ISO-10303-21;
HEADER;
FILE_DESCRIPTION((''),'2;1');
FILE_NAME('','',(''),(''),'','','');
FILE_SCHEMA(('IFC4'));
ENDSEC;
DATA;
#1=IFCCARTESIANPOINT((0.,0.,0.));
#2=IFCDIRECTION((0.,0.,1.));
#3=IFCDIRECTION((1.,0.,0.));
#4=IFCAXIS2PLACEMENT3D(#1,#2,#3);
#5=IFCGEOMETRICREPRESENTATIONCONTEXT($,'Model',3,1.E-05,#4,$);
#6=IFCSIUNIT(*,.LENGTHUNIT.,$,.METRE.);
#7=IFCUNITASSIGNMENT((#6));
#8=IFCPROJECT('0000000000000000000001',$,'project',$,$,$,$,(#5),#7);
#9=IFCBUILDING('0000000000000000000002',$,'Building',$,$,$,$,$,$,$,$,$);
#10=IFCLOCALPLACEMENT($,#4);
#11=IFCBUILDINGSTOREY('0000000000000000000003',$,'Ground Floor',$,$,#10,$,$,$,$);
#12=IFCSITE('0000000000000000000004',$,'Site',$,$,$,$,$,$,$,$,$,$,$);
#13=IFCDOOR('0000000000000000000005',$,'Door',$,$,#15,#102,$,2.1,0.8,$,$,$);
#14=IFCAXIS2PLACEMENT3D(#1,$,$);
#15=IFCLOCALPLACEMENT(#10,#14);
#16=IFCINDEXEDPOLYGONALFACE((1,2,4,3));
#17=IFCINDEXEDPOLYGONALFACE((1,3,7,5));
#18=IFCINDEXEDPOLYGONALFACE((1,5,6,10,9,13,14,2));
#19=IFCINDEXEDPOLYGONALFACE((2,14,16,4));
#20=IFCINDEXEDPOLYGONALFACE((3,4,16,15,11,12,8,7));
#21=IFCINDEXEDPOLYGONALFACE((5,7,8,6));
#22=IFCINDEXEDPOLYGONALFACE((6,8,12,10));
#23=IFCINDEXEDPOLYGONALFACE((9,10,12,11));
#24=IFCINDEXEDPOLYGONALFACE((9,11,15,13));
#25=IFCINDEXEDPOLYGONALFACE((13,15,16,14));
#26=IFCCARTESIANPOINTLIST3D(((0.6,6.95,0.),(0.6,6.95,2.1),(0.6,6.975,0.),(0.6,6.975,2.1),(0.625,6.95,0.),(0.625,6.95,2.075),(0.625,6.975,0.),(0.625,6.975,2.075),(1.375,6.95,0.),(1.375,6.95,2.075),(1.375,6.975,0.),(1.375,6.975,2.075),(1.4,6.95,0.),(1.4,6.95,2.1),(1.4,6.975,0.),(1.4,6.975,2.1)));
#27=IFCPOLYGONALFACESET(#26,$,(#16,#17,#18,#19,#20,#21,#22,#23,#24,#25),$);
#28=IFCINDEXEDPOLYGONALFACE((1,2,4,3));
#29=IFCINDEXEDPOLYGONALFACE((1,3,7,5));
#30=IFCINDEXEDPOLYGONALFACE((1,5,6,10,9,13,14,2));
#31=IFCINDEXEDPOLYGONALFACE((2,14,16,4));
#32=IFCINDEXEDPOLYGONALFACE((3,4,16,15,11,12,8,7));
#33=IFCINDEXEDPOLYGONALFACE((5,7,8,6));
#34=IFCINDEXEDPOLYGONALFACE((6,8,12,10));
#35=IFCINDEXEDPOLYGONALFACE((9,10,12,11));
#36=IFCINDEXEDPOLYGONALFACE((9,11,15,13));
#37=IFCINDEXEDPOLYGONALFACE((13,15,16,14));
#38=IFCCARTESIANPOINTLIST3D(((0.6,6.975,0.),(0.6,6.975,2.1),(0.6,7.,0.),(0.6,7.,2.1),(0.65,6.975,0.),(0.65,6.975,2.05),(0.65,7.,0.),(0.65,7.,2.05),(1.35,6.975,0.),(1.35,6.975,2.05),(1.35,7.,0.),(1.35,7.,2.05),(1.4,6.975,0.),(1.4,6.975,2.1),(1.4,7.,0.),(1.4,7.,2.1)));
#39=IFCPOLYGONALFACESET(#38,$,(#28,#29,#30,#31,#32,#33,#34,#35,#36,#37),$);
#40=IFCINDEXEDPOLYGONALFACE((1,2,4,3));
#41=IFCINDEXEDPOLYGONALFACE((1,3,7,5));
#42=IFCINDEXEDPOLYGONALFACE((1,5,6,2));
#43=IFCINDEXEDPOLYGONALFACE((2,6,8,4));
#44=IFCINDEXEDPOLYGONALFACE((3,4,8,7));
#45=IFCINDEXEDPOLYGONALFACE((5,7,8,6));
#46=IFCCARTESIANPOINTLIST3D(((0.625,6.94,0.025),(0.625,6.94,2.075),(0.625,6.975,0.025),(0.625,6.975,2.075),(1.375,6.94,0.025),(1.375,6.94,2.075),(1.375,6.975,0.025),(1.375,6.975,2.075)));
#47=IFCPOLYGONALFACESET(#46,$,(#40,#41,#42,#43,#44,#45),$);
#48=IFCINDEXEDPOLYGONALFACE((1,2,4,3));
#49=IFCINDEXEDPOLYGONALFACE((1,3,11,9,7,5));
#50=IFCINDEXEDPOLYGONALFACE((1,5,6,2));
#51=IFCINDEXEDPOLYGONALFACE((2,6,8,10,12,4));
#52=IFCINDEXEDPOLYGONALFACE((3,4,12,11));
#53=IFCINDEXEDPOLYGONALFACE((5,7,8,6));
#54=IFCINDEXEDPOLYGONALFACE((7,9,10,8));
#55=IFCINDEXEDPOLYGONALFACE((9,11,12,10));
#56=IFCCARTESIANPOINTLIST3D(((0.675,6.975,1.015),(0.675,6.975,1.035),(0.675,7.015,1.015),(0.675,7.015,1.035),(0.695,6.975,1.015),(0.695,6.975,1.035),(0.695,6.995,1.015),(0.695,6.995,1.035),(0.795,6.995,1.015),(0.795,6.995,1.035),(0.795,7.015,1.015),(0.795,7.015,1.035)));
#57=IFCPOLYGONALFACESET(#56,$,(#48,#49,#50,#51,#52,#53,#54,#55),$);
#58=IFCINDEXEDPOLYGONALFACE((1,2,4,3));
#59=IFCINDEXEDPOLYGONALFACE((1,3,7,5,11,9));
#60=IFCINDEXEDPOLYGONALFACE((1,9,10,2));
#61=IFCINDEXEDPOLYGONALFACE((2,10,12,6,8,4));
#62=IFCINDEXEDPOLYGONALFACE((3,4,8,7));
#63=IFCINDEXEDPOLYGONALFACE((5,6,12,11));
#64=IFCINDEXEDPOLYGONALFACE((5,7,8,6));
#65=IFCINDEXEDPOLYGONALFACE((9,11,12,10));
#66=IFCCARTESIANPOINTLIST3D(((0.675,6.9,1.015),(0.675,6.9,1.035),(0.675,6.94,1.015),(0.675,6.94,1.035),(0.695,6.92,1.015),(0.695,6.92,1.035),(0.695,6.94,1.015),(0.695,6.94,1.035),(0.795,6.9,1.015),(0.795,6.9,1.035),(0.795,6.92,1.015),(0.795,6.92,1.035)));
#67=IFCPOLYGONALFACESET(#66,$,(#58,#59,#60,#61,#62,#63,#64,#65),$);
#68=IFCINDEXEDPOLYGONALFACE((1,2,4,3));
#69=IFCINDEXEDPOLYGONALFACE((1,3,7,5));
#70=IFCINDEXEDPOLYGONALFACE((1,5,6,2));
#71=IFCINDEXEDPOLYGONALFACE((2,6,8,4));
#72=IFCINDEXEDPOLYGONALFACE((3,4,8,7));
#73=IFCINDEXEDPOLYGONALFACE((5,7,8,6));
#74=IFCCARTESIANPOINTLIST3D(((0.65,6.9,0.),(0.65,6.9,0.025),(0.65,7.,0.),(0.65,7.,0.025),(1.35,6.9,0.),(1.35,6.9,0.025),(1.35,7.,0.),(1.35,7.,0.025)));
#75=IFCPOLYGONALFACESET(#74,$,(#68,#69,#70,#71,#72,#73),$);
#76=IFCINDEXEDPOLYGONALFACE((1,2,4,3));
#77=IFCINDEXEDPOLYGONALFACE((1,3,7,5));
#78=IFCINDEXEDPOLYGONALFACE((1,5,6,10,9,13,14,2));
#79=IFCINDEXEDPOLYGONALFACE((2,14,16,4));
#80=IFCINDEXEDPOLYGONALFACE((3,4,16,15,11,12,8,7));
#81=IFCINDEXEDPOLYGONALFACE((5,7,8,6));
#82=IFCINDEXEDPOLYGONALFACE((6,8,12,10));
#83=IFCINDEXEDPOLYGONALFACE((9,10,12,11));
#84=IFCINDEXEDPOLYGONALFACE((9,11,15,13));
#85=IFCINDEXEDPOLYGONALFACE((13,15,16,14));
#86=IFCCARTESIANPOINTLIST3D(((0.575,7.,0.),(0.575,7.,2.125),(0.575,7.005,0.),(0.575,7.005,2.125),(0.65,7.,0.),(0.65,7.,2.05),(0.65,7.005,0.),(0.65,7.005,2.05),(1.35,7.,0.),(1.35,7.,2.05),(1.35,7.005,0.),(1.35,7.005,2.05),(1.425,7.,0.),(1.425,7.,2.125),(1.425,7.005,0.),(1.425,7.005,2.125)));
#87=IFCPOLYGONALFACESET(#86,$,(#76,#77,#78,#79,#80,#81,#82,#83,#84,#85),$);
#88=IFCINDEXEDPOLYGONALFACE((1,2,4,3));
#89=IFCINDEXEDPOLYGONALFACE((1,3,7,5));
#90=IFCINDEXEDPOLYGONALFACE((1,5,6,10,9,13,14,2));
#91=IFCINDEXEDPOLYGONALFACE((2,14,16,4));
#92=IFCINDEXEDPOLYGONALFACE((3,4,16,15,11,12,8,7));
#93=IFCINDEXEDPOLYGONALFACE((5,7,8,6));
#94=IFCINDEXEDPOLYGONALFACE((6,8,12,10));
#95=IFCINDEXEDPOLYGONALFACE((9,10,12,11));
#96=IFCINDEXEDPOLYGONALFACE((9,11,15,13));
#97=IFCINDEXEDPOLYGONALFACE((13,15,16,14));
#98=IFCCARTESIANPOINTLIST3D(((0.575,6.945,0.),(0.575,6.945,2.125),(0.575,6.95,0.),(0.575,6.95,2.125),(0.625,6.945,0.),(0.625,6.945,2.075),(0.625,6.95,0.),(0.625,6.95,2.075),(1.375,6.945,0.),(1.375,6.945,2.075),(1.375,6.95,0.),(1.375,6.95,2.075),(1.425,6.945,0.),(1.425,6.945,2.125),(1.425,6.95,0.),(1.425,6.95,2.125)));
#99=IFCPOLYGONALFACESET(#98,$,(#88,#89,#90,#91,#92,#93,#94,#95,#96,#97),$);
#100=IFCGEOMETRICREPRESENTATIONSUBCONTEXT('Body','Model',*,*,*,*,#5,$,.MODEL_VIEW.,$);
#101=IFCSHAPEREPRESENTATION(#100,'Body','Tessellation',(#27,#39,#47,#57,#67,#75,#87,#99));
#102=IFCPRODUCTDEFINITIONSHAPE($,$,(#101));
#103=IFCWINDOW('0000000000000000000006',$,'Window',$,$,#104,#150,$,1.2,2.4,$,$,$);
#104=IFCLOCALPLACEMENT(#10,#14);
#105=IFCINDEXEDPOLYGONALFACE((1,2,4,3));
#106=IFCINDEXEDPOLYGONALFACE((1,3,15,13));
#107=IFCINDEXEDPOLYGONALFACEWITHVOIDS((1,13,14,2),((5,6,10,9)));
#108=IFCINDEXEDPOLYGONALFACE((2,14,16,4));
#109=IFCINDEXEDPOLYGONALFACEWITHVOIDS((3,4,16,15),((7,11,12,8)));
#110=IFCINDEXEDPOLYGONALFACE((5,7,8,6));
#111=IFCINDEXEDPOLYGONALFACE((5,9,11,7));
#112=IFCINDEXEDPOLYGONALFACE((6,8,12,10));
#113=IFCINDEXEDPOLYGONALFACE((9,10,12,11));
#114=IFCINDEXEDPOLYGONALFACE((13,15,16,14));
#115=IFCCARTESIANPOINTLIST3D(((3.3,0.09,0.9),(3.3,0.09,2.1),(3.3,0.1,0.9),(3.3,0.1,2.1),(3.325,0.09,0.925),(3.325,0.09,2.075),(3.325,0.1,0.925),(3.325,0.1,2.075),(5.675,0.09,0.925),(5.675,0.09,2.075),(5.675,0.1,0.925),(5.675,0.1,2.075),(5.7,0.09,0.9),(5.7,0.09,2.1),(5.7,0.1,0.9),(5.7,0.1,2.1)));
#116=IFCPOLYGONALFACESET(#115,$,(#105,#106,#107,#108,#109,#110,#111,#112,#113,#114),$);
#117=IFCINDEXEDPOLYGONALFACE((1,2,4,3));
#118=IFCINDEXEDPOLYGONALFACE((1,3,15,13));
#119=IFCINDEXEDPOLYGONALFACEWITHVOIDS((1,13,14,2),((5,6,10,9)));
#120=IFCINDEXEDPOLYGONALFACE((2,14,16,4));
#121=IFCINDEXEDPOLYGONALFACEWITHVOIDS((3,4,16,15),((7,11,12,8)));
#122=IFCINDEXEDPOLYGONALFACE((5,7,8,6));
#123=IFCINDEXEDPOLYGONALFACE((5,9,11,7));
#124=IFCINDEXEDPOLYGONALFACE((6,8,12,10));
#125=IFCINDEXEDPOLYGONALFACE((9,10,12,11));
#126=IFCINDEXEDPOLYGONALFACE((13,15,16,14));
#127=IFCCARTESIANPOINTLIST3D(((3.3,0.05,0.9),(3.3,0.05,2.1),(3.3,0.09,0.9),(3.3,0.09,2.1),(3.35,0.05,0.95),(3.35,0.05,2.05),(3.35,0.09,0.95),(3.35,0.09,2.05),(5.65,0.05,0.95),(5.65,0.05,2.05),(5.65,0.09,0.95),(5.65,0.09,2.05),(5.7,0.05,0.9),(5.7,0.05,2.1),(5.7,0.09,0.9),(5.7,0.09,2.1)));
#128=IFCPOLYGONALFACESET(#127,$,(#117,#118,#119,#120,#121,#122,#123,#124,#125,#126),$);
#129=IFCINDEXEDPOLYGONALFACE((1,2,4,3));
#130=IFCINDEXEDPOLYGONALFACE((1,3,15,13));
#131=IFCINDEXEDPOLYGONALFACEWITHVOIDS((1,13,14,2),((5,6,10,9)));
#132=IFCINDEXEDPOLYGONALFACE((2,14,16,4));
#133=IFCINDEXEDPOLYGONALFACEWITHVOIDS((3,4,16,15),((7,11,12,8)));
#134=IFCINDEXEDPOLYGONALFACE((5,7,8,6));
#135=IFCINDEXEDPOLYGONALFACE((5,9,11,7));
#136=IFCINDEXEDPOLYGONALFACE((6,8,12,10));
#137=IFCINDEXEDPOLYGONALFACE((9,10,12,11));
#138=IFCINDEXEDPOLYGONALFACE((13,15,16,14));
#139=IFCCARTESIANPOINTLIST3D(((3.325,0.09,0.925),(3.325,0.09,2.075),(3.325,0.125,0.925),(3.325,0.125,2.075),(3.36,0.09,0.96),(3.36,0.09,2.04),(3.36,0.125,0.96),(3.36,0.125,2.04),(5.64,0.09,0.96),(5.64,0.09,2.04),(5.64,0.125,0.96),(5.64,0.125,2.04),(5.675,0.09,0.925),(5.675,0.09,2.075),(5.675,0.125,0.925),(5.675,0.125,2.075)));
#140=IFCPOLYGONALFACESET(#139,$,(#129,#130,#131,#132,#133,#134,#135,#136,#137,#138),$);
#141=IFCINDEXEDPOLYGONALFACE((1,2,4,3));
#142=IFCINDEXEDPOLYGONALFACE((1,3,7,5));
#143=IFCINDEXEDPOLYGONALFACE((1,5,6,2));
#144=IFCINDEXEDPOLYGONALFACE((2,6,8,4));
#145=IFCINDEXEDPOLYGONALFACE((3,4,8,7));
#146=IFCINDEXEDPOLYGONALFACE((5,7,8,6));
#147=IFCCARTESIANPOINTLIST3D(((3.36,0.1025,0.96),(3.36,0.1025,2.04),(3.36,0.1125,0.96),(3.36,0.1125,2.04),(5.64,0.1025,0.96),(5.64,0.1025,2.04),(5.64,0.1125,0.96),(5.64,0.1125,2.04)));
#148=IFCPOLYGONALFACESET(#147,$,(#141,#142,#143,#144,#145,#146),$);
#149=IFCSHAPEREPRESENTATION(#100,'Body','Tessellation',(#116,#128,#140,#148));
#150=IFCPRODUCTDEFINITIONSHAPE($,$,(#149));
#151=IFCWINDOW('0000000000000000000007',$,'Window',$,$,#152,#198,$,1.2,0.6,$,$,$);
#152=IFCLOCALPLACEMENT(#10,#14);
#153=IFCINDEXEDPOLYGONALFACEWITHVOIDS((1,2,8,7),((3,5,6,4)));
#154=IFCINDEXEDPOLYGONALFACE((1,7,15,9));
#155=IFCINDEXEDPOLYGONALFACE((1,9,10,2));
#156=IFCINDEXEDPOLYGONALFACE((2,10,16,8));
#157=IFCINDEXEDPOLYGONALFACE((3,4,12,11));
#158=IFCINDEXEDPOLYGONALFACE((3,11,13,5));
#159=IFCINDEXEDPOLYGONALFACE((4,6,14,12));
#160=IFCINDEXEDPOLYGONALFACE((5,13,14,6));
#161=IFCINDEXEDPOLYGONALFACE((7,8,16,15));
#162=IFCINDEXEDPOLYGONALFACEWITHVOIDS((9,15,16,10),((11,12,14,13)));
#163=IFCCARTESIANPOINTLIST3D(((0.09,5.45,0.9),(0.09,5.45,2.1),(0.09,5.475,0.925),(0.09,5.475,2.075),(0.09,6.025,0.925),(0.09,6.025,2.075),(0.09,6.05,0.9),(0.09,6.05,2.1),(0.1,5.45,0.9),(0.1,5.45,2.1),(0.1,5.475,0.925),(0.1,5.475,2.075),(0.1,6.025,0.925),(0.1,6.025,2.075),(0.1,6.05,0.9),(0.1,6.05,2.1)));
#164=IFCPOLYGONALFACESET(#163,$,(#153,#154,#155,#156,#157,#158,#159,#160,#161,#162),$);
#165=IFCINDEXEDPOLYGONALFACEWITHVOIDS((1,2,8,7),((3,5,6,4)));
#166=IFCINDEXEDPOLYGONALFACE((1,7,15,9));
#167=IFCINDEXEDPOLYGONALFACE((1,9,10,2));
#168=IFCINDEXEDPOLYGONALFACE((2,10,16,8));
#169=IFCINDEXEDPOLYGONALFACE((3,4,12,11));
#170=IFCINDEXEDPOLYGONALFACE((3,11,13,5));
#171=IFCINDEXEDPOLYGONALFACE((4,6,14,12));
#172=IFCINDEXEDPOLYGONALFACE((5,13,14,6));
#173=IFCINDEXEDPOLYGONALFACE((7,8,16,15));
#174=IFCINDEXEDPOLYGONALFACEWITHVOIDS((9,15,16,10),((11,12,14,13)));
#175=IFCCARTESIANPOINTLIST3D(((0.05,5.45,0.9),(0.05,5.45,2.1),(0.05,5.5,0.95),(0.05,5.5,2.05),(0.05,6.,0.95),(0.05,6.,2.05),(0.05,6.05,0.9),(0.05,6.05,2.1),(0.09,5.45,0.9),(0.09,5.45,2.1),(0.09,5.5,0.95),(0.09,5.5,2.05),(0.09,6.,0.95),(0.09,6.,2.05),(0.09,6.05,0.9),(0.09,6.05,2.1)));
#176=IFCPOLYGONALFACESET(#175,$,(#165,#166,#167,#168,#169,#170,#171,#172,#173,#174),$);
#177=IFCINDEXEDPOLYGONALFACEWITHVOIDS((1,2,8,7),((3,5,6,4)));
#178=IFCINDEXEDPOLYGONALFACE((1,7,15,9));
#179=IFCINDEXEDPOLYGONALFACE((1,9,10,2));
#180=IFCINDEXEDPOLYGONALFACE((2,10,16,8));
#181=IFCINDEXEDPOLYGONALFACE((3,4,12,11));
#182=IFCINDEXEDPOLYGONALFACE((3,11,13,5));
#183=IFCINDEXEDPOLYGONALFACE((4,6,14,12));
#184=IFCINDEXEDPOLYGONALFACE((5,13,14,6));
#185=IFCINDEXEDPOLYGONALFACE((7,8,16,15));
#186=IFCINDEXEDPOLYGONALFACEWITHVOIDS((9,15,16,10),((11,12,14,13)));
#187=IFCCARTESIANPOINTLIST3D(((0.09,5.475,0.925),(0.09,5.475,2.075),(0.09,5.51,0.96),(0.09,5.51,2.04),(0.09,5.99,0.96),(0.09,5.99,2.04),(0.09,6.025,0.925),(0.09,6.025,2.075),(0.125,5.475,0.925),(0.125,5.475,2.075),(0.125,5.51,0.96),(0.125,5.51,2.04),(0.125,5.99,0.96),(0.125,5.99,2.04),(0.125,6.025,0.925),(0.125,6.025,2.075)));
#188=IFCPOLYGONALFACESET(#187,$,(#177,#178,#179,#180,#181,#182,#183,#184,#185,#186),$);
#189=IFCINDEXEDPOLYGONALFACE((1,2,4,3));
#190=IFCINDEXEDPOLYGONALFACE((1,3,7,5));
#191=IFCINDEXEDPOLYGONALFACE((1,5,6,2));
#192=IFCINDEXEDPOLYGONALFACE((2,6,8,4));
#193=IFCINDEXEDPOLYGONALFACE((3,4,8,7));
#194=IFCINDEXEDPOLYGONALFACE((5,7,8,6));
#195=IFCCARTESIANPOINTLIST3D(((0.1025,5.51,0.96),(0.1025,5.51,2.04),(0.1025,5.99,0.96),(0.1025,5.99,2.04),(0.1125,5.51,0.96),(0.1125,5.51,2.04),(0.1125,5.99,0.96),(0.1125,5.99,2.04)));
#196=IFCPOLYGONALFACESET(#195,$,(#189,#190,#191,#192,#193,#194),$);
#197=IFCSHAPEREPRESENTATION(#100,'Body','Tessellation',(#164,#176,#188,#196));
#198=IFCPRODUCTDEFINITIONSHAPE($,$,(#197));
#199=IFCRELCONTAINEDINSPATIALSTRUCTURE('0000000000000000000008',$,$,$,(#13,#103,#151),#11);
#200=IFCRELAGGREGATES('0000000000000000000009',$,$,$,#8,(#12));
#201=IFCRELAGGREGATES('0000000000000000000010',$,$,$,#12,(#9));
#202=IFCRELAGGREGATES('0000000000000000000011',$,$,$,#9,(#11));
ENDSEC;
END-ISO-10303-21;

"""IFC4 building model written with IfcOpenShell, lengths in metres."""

from ifc_helpers import new_model, si_unit, frame, origin_with_axes, place, context, subcontext, project, spatial, line, indexed_curve, outline, extrude, element, save


model = new_model("IFC4")

# Units and contexts
model_context = context("Model", 3, precision=1e-05, world=origin_with_axes())
body_context = subcontext(model_context, "Body", "Model", "MODEL_VIEW")
ifc_project = project(units=[si_unit("LENGTHUNIT", "METRE")], contexts=[model_context])

# Site, building, storey
site = spatial("IfcSite", under=ifc_project, Name="Site")
building = spatial("IfcBuilding", under=site, Name="Building")
storey_placement = place(None, origin_with_axes())
storey = spatial("IfcBuildingStorey", under=building, at=storey_placement, Name="Ground Floor")

# Door
door_1_placement = place(storey_placement, frame((1.4, 7.0, 0.0), z_axis=(0.0, 0.0, 1.0), x_axis=(-1.0, 0.0, 0.0)))
element("IfcDoor", 1, at=door_1_placement, inside=storey, Name="Door", OverallHeight=2.1, OverallWidth=0.8, context=body_context, shape_type="SweptSolid", body=[
    extrude(outline(indexed_curve([(0.0, 0.0), (0.0, 2.1), (0.8, 2.1), (0.8, 0.0), (0.775, 0.0), (0.775, 2.075), (0.025, 2.075), (0.025, 0.0)], segments=[line(1, 2, 3, 4, 5, 6, 7, 8, 1)])), frame((0.0, 0.025, 0.0), z_axis=(0.0, -1.0, 0.0), x_axis=(1.0, 0.0, 0.0)), (0.0, 0.0, -1.0), 0.025),
    extrude(outline(indexed_curve([(0.0, 0.0), (0.0, 2.1), (0.8, 2.1), (0.8, 0.0), (0.75, 0.0), (0.75, 2.05), (0.05, 2.05), (0.05, 0.0)], segments=[line(1, 2, 3, 4, 5, 6, 7, 8, 1)])), frame((0.0, 0.0, 0.0), z_axis=(0.0, -1.0, 0.0), x_axis=(1.0, 0.0, 0.0)), (0.0, 0.0, -1.0), 0.025),
    extrude(outline(indexed_curve([(0.0, 0.0), (0.75, 0.0), (0.75, 0.035), (0.0, 0.035)], segments=[line(1, 2, 3, 4, 1)])), frame((0.025, 0.025, 0.025), z_axis=(0.0, 0.0, 1.0), x_axis=(1.0, 0.0, 0.0)), (0.0, 0.0, 1.0), 2.05),
    extrude(outline(indexed_curve([(0.0, 0.0), (0.0, -0.04), (-0.12, -0.04), (-0.12, -0.02), (-0.02, -0.02), (-0.02, 0.0)], segments=[line(1, 2, 3, 4, 5, 6, 1)])), frame((0.725, 0.025, 1.015), z_axis=(0.0, 0.0, 1.0), x_axis=(1.0, 0.0, 0.0)), (0.0, 0.0, 1.0), 0.02),
    extrude(outline(indexed_curve([(0.0, 0.0), (0.0, 0.04), (-0.12, 0.04), (-0.12, 0.02), (-0.02, 0.02), (-0.02, 0.0)], segments=[line(1, 2, 3, 4, 5, 6, 1)])), frame((0.725, 0.06, 1.015), z_axis=(0.0, 0.0, 1.0), x_axis=(1.0, 0.0, 0.0)), (0.0, 0.0, 1.0), 0.02),
    extrude(outline(indexed_curve([(0.0, 0.0), (0.7, 0.0), (0.7, 0.1), (0.0, 0.1)], segments=[line(1, 2, 3, 4, 1)])), frame((0.05, 0.0, 0.0), z_axis=(0.0, 0.0, 1.0), x_axis=(1.0, 0.0, 0.0)), (0.0, 0.0, 1.0), 0.025),
    extrude(outline(indexed_curve([(0.0, 0.0), (0.0, 2.125), (0.85, 2.125), (0.85, 0.0), (0.775, 0.0), (0.775, 2.05), (0.075, 2.05), (0.075, 0.0)], segments=[line(1, 2, 3, 4, 5, 6, 7, 8, 1)])), frame((-0.025, -0.005, 0.0), z_axis=(0.0, -1.0, 0.0), x_axis=(1.0, 0.0, 0.0)), (0.0, 0.0, -1.0), 0.005),
    extrude(outline(indexed_curve([(0.0, 0.0), (0.0, 2.125), (0.85, 2.125), (0.85, 0.0), (0.8, 0.0), (0.8, 2.075), (0.05, 2.075), (0.05, 0.0)], segments=[line(1, 2, 3, 4, 5, 6, 7, 8, 1)])), frame((-0.025, 0.05, 0.0), z_axis=(0.0, -1.0, 0.0), x_axis=(1.0, 0.0, 0.0)), (0.0, 0.0, -1.0), 0.005),
])

# Windows
window_1_placement = place(storey_placement, frame((3.3, 0.0, 0.9), z_axis=(0.0, 0.0, 1.0), x_axis=(1.0, 0.0, 0.0)))
element("IfcWindow", 2, at=window_1_placement, inside=storey, Name="Window", OverallHeight=1.2, OverallWidth=2.4, context=body_context, shape_type="SweptSolid", body=[
    extrude(outline(indexed_curve([(0.0, 0.0), (2.4, 0.0), (2.4, 1.2), (0.0, 1.2)], segments=[line(1, 2, 3, 4, 1)]), holes=[indexed_curve([(0.025, 0.025), (2.375, 0.025), (2.375, 1.175), (0.025, 1.175)], segments=[line(1, 2, 3, 4, 1)])]), frame((0.0, 0.09, 0.0), z_axis=(0.0, -1.0, 0.0), x_axis=(1.0, 0.0, 0.0)), (0.0, 0.0, -1.0), 0.01),
    extrude(outline(indexed_curve([(0.0, 0.0), (2.4, 0.0), (2.4, 1.2), (0.0, 1.2)], segments=[line(1, 2, 3, 4, 1)]), holes=[indexed_curve([(0.05, 0.05), (2.35, 0.05), (2.35, 1.15), (0.05, 1.15)], segments=[line(1, 2, 3, 4, 1)])]), frame((0.0, 0.05, 0.0), z_axis=(0.0, -1.0, 0.0), x_axis=(1.0, 0.0, 0.0)), (0.0, 0.0, -1.0), 0.04),
    extrude(outline(indexed_curve([(0.0, 0.0), (2.35, 0.0), (2.35, 1.15), (0.0, 1.15)], segments=[line(1, 2, 3, 4, 1)]), holes=[indexed_curve([(0.035, 0.035), (2.315, 0.035), (2.315, 1.115), (0.035, 1.115)], segments=[line(1, 2, 3, 4, 1)])]), frame((0.025, 0.09, 0.025), z_axis=(0.0, -1.0, 0.0), x_axis=(1.0, 0.0, 0.0)), (0.0, 0.0, -1.0), 0.035),
    extrude(outline(indexed_curve([(0.035, 0.035), (2.315, 0.035), (2.315, 1.115), (0.035, 1.115)], segments=[line(1, 2, 3, 4, 1)])), frame((0.025, 0.1025, 0.025), z_axis=(0.0, -1.0, 0.0), x_axis=(1.0, 0.0, 0.0)), (0.0, 0.0, -1.0), 0.01),
])
window_2_placement = place(storey_placement, frame((0.0, 6.05, 0.9), z_axis=(0.0, 0.0, 1.0), x_axis=(0.0, -1.0, 0.0)))
element("IfcWindow", 3, at=window_2_placement, inside=storey, Name="Window", OverallHeight=1.2, OverallWidth=0.6, context=body_context, shape_type="SweptSolid", body=[
    extrude(outline(indexed_curve([(0.0, 0.0), (0.6, 0.0), (0.6, 1.2), (0.0, 1.2)], segments=[line(1, 2, 3, 4, 1)]), holes=[indexed_curve([(0.025, 0.025), (0.575, 0.025), (0.575, 1.175), (0.025, 1.175)], segments=[line(1, 2, 3, 4, 1)])]), frame((0.0, 0.09, 0.0), z_axis=(0.0, -1.0, 0.0), x_axis=(1.0, 0.0, 0.0)), (0.0, 0.0, -1.0), 0.01),
    extrude(outline(indexed_curve([(0.0, 0.0), (0.6, 0.0), (0.6, 1.2), (0.0, 1.2)], segments=[line(1, 2, 3, 4, 1)]), holes=[indexed_curve([(0.05, 0.05), (0.55, 0.05), (0.55, 1.15), (0.05, 1.15)], segments=[line(1, 2, 3, 4, 1)])]), frame((0.0, 0.05, 0.0), z_axis=(0.0, -1.0, 0.0), x_axis=(1.0, 0.0, 0.0)), (0.0, 0.0, -1.0), 0.04),
    extrude(outline(indexed_curve([(0.0, 0.0), (0.55, 0.0), (0.55, 1.15), (0.0, 1.15)], segments=[line(1, 2, 3, 4, 1)]), holes=[indexed_curve([(0.035, 0.035), (0.515, 0.035), (0.515, 1.115), (0.035, 1.115)], segments=[line(1, 2, 3, 4, 1)])]), frame((0.025, 0.09, 0.025), z_axis=(0.0, -1.0, 0.0), x_axis=(1.0, 0.0, 0.0)), (0.0, 0.0, -1.0), 0.035),
    extrude(outline(indexed_curve([(0.035, 0.035), (0.515, 0.035), (0.515, 1.115), (0.035, 1.115)], segments=[line(1, 2, 3, 4, 1)])), frame((0.025, 0.1025, 0.025), z_axis=(0.0, -1.0, 0.0), x_axis=(1.0, 0.0, 0.0)), (0.0, 0.0, -1.0), 0.01),
])

save(model, "model.ifc")
